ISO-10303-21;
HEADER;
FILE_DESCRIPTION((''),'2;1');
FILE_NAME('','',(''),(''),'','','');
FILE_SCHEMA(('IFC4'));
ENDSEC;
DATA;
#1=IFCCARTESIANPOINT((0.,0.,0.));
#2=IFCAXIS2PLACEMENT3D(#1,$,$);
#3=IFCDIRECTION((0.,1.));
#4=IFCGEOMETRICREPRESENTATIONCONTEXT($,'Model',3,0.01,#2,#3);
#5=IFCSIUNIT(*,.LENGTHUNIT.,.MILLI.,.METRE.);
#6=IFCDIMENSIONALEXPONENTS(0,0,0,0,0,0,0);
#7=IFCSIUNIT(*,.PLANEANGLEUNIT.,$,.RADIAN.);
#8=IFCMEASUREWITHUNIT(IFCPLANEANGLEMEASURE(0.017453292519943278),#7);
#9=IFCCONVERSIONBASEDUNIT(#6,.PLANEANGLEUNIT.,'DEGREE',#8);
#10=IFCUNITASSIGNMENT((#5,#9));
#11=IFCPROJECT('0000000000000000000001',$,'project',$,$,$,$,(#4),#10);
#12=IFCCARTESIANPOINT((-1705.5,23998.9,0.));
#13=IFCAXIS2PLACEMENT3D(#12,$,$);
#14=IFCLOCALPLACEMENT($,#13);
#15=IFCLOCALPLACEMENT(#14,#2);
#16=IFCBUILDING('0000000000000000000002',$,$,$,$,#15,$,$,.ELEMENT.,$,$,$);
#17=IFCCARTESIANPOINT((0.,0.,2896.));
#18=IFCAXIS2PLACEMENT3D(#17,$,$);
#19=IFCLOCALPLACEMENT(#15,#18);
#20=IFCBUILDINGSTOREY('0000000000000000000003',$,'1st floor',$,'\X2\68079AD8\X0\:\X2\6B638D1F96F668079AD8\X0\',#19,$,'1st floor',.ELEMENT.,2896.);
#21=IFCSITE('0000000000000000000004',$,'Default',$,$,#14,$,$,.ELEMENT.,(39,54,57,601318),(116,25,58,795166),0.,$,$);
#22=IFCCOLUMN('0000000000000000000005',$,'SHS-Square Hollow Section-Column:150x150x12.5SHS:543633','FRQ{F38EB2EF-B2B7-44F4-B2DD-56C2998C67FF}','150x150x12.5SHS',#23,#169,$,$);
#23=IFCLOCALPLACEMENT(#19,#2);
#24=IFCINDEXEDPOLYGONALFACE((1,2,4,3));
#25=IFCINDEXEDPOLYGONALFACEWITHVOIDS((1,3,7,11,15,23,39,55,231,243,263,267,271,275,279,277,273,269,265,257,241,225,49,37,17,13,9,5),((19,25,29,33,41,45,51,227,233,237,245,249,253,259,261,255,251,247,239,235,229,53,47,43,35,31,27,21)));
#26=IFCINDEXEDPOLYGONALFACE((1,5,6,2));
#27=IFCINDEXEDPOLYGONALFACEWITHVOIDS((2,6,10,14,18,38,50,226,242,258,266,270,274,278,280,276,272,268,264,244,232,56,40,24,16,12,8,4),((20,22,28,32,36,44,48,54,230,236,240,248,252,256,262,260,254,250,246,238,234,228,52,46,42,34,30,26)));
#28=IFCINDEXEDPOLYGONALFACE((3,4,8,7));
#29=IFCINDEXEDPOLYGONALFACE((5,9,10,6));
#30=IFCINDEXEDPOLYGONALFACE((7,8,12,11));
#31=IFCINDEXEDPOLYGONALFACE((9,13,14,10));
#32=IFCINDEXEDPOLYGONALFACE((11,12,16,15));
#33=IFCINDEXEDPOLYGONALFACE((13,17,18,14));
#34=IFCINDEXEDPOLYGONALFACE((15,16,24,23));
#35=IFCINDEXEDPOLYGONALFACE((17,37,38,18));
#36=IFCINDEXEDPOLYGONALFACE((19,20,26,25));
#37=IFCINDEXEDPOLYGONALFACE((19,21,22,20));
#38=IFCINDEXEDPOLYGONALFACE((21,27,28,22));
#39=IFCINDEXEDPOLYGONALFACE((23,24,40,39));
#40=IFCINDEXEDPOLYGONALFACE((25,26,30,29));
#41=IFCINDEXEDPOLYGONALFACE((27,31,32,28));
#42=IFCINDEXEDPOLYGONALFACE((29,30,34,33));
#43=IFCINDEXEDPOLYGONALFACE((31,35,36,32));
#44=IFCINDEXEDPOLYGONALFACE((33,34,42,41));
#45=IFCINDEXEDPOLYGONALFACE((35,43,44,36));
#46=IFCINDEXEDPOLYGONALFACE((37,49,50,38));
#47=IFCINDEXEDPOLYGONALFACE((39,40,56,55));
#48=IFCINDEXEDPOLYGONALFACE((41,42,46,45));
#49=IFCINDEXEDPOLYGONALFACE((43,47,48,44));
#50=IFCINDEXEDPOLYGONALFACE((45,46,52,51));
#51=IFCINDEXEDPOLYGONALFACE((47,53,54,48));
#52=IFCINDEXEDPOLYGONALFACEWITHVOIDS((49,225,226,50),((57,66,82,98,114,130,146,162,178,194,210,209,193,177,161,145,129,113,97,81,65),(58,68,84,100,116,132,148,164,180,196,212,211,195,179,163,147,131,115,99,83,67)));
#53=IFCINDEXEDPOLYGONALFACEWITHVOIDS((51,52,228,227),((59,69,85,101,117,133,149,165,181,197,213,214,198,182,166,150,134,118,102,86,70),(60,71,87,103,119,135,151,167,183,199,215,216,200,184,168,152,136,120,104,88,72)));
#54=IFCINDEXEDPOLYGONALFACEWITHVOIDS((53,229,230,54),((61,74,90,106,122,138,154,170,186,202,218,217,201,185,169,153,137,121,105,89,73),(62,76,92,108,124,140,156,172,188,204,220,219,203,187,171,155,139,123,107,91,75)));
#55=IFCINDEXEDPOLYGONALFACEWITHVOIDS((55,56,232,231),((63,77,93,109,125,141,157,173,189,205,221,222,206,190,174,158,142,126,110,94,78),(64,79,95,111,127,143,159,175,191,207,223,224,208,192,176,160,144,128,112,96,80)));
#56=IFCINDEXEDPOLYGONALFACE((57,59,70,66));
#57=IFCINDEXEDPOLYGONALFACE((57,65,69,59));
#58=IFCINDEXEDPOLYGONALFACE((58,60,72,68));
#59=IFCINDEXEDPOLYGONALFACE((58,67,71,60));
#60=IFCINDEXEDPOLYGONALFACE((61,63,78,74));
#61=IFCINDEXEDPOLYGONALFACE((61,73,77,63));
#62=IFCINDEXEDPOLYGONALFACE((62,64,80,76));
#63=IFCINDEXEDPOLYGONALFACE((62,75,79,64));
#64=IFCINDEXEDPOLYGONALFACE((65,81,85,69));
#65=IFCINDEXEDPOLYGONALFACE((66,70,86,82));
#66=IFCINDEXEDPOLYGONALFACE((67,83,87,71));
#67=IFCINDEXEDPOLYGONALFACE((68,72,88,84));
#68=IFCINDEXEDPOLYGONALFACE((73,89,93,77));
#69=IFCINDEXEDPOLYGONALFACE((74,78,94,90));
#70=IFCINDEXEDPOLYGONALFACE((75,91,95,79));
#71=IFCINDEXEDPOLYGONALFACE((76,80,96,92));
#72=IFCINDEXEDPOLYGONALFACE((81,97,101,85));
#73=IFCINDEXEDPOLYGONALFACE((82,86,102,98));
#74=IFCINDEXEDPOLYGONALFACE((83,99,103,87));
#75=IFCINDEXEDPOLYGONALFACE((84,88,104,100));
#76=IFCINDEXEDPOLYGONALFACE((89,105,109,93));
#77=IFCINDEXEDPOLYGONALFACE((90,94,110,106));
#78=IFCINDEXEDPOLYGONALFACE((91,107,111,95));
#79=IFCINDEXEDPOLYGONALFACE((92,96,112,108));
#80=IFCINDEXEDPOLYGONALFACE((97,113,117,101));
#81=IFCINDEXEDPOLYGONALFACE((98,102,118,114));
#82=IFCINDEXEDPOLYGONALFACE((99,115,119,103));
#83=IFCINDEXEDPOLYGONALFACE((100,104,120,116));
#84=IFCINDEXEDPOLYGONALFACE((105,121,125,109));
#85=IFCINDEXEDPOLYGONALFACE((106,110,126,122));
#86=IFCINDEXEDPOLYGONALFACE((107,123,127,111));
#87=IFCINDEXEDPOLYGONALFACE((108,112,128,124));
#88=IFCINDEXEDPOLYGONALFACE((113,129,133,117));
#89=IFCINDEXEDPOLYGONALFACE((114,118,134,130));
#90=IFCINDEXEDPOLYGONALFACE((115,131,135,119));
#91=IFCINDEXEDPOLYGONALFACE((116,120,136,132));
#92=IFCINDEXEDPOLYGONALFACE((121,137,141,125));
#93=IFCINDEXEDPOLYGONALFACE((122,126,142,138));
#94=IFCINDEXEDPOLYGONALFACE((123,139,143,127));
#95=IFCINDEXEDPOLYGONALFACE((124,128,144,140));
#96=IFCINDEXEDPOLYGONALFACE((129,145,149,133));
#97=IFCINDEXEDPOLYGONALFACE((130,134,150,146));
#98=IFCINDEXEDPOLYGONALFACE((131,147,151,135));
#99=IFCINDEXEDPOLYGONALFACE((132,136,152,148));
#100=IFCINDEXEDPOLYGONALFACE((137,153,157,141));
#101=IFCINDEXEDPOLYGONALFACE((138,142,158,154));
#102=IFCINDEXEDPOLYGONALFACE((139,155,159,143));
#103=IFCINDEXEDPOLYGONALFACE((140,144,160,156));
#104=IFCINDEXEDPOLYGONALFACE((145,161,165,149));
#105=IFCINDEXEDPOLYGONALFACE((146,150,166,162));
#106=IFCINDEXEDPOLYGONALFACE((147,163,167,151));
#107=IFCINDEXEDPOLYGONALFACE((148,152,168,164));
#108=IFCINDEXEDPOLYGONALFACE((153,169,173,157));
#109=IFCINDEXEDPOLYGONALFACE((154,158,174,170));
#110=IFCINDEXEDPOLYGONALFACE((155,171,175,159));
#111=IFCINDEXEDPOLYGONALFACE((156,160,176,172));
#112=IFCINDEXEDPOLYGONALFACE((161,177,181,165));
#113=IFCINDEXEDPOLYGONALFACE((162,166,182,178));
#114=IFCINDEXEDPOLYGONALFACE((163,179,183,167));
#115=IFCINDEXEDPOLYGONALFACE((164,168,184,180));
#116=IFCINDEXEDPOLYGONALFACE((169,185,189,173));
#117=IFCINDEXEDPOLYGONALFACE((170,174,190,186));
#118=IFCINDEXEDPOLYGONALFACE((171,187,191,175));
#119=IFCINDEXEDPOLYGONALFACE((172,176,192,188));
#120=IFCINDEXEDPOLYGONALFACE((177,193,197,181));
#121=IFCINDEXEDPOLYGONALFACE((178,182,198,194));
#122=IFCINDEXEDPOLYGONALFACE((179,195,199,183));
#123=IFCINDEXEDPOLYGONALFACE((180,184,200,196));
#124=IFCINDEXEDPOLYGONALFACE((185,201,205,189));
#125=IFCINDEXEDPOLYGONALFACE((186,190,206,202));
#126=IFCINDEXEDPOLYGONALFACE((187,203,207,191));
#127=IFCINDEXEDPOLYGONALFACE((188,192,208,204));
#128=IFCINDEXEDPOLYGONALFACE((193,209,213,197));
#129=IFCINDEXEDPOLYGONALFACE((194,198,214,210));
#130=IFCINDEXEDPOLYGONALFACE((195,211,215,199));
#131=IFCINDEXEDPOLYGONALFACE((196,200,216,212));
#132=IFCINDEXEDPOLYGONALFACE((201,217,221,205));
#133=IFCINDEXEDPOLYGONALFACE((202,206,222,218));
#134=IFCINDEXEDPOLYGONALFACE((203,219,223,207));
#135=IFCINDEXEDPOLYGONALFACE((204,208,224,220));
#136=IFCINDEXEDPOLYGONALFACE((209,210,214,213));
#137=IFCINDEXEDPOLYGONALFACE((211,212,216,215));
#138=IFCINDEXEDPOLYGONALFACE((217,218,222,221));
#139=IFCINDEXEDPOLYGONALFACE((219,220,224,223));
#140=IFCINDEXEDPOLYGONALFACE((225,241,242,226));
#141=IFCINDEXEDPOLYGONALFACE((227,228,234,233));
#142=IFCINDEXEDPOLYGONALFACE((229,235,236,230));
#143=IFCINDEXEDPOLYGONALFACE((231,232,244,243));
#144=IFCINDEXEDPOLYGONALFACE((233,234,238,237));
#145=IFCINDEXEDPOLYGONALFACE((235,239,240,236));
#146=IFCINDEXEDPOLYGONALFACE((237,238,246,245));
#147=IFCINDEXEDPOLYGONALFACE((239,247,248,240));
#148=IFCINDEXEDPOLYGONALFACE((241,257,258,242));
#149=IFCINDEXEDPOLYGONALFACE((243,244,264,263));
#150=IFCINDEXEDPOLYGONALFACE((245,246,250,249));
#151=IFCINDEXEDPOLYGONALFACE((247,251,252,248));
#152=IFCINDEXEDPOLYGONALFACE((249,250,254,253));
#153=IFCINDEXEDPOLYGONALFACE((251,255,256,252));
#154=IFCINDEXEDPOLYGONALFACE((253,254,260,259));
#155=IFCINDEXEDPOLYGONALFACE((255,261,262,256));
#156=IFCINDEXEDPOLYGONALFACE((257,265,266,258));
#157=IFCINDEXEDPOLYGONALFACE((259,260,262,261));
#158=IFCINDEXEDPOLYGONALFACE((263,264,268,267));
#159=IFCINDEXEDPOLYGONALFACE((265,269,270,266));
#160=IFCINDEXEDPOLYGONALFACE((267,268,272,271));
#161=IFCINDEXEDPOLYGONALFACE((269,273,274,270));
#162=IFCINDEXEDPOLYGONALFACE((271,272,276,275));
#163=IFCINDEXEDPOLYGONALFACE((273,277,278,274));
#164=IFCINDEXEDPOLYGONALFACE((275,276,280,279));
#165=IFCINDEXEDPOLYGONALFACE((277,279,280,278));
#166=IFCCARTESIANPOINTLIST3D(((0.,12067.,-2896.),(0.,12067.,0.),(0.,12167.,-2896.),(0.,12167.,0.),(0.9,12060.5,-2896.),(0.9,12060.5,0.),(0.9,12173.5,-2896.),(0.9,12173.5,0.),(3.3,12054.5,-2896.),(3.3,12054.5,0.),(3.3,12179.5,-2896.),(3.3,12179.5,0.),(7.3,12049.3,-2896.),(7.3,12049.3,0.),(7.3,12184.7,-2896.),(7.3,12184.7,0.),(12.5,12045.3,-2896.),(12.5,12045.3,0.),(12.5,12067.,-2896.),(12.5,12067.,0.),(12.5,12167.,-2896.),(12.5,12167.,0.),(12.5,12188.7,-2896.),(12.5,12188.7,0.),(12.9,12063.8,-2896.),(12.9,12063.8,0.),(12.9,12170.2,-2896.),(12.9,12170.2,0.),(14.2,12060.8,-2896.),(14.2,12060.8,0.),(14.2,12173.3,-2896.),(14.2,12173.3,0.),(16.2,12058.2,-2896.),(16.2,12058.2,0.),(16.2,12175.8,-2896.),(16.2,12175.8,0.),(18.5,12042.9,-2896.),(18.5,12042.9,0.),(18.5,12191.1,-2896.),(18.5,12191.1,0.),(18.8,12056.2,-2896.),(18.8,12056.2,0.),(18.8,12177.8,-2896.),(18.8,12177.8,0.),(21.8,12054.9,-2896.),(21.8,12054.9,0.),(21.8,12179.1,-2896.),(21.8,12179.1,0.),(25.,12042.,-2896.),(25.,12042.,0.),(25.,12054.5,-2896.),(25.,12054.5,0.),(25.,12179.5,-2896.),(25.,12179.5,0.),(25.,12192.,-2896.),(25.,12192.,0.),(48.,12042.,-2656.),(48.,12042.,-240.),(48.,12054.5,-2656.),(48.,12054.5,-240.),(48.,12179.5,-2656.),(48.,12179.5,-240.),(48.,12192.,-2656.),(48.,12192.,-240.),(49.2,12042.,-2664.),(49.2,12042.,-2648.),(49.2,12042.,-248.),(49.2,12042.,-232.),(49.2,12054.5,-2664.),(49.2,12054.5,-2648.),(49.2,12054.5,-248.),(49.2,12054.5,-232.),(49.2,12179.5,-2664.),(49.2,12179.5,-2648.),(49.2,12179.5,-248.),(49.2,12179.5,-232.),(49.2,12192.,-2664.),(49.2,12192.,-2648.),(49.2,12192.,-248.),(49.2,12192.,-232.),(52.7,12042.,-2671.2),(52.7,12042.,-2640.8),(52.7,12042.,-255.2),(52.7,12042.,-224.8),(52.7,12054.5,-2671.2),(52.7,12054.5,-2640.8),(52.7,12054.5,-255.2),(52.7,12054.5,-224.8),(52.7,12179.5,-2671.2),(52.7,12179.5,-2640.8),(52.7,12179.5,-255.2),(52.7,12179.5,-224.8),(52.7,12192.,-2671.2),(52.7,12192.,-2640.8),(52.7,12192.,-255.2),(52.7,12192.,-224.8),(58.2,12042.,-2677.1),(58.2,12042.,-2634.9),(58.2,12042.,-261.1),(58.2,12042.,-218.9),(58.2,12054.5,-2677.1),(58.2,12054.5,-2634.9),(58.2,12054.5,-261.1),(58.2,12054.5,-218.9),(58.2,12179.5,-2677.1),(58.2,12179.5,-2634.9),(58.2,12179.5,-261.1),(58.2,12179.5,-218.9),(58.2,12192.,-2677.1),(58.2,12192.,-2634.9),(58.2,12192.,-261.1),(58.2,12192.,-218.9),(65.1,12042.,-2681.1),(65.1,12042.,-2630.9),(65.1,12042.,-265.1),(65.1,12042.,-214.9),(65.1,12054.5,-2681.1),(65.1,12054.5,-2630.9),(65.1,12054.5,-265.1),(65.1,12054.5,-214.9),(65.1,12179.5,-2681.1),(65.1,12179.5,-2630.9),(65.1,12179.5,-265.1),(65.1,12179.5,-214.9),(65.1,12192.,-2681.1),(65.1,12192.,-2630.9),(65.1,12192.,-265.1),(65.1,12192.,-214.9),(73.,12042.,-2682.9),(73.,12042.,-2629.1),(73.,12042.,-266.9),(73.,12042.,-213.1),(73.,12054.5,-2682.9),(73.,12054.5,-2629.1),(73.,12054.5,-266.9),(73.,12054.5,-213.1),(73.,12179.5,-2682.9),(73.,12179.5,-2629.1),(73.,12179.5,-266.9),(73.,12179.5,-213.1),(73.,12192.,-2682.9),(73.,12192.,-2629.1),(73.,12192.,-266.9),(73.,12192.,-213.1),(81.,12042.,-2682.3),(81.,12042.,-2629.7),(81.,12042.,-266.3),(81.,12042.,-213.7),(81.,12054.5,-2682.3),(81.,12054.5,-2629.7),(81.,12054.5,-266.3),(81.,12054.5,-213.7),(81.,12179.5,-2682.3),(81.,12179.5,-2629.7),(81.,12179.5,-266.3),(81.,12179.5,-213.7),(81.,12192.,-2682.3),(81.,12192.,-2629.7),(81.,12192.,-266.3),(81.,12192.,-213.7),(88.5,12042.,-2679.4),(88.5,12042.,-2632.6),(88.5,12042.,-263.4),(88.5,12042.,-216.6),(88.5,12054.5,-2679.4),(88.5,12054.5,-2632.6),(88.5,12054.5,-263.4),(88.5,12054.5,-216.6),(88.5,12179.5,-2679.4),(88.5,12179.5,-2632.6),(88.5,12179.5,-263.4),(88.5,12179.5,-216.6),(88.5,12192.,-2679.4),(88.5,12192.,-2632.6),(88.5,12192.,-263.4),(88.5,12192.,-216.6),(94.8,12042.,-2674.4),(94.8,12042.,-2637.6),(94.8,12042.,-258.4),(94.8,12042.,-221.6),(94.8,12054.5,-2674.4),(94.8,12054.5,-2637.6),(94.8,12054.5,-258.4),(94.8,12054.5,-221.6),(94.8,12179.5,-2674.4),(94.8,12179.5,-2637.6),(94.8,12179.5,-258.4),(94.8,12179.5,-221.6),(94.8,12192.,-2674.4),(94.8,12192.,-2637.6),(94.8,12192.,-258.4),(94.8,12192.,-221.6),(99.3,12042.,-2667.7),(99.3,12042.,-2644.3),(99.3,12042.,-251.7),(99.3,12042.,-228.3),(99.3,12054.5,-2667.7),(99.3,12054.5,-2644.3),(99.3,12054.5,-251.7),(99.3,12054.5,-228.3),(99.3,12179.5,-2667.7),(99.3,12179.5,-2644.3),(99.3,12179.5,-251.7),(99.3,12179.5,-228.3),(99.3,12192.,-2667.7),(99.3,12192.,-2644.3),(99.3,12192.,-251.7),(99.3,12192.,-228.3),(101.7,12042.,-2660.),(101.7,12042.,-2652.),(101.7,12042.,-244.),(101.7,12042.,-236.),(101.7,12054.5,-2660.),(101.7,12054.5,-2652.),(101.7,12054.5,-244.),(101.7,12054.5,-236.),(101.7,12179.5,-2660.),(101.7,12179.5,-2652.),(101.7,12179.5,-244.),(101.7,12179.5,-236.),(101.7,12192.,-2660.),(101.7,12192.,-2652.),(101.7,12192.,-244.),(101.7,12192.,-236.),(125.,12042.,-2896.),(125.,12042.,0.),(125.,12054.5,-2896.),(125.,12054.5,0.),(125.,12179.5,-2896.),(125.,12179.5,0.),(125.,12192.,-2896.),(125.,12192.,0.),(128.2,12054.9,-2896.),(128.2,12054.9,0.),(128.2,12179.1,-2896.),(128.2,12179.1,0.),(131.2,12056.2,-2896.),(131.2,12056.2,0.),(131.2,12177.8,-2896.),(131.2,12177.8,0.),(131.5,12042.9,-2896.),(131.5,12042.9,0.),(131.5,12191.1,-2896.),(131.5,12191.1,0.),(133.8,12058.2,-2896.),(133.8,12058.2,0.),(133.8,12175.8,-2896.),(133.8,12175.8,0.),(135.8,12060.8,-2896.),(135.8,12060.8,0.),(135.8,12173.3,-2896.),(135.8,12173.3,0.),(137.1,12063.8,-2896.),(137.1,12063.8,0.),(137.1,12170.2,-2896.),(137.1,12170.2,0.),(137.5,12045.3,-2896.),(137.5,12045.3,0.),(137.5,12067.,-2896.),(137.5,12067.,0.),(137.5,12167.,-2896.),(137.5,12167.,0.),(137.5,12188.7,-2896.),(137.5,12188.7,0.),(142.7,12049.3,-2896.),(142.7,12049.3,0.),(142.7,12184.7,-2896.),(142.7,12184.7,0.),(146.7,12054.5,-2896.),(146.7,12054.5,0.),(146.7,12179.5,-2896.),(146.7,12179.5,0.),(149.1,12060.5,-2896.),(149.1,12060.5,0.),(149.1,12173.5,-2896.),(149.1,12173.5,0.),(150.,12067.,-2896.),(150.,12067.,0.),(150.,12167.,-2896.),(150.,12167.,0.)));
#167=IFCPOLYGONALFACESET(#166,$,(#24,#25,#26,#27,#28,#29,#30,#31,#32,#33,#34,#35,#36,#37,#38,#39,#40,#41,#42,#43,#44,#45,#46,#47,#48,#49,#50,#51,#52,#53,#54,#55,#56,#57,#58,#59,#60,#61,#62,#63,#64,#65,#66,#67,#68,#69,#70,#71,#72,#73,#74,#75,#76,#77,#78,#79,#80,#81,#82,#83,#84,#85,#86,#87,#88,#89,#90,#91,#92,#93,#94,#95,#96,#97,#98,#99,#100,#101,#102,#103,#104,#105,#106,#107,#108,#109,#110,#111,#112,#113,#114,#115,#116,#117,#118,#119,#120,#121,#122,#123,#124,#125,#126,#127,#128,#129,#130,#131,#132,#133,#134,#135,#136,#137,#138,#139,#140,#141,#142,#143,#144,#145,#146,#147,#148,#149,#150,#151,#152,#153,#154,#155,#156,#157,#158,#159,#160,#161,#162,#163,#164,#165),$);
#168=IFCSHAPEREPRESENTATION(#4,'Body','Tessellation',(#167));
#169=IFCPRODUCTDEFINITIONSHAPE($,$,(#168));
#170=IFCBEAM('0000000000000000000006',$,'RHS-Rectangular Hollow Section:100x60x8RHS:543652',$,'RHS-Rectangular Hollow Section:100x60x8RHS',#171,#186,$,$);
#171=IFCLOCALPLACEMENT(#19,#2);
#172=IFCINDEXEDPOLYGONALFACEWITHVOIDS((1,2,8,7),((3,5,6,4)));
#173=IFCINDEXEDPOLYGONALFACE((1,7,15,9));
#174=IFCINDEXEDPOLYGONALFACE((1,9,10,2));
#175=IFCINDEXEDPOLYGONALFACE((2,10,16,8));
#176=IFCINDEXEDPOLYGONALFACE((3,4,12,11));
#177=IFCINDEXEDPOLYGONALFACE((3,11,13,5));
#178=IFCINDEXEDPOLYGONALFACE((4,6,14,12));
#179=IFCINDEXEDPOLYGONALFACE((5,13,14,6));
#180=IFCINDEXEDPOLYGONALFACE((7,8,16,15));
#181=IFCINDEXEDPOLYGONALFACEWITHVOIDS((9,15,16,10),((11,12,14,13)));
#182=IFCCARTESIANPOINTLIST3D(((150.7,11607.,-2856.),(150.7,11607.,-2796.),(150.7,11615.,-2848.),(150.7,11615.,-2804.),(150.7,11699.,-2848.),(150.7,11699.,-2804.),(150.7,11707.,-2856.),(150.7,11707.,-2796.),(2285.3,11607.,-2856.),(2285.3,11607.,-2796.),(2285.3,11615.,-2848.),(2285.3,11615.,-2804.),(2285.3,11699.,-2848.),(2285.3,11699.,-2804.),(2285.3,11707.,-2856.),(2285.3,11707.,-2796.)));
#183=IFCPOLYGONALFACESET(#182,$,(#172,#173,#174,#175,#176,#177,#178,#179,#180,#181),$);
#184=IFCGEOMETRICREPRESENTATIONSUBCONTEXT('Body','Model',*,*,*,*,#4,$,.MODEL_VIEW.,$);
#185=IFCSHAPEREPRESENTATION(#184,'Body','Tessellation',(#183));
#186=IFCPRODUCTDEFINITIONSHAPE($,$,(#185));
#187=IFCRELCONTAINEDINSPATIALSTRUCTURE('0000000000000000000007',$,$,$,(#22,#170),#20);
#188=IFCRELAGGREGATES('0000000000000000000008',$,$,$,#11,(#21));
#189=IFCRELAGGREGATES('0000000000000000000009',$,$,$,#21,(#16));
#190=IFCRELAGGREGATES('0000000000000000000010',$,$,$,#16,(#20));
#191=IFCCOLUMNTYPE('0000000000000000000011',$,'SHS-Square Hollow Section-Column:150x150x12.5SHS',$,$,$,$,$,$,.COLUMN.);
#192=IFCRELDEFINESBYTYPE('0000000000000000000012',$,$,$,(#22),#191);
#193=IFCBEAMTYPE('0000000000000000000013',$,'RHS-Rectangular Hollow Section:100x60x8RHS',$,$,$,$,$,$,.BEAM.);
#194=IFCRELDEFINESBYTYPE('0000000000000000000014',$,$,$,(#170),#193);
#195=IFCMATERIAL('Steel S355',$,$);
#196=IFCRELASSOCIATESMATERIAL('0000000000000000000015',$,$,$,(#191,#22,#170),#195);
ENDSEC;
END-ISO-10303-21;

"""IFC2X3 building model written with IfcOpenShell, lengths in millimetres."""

from ifc_helpers import new_model, entity, si_unit, converted_unit, direction, frame, frame_2d, origin, origin_2d, place, context, subcontext, project, spatial, circle_curve, rectangle, hollow_rectangle, outline, extrude, boolean, material, type_object, element, save


model = new_model("IFC2X3")

# Units and contexts
model_context = context("Model", 3, precision=0.01, world=origin(), true_north=direction((0.0, 1.0)))
body_context = subcontext(model_context, "Body", "Model", "MODEL_VIEW")
ifc_project = project(units=[si_unit("LENGTHUNIT", "METRE", prefix="MILLI"), converted_unit("PLANEANGLEUNIT", "DEGREE", entity("IfcPlaneAngleMeasure", 0.017453292519943278), si_unit("PLANEANGLEUNIT", "RADIAN"), dimensions=[0, 0, 0, 0, 0, 0, 0])], contexts=[model_context])

# Site, building, storey
site_placement = place(None, frame((-1705.5, 23998.9, 0.0)))
site = spatial("IfcSite", under=ifc_project, at=site_placement, Name="Default", CompositionType="ELEMENT", RefLatitude=(39, 54, 57, 601318), RefLongitude=(116, 25, 58, 795166), RefElevation=0.0)
building_placement = place(site_placement, origin())
building = spatial("IfcBuilding", under=site, at=building_placement, CompositionType="ELEMENT")
storey_placement = place(building_placement, frame((0.0, 0.0, 2896.0)))
storey = spatial("IfcBuildingStorey", under=building, at=storey_placement, Name="1st floor", ObjectType="标高:正负零标高", LongName="1st floor", CompositionType="ELEMENT", Elevation=2896.0)

# Shared definitions
ifc_material_1 = material(Name="Steel S355")

# Column, openings
column_type_1 = type_object("IfcColumnType", Name="SHS-Square Hollow Section-Column:150x150x12.5SHS", PredefinedType="COLUMN", material=ifc_material_1)
column_1_placement = place(storey_placement, frame((75.0, 12117.0, 0.0), z_axis=(0.0, 0.0, 1.0), x_axis=(0.0, -1.0, 0.0)))
column_1 = element("IfcColumn", 1, at=column_1_placement, inside=storey, type_object=column_type_1, material=ifc_material_1, Name="SHS-Square Hollow Section-Column:150x150x12.5SHS:543633", Description="FRQ{F38EB2EF-B2B7-44F4-B2DD-56C2998C67FF}", ObjectType="150x150x12.5SHS", context=model_context, shape_type="SweptSolid", body=[
    extrude(hollow_rectangle(XDim=150.0, YDim=150.0, WallThickness=12.5, InnerFilletRadius=12.5, OuterFilletRadius=25.0, at=origin_2d()), origin(), (0.0, 0.0, -1.0), 2896.0),
])
opening_1_placement = place(column_1_placement, frame((175.1, 0.0, -2896.0), z_axis=(-1.0, 0.0, 0.0), x_axis=(0.0, -1.0, 0.0)))
element("IfcOpeningElement", 2, at=opening_1_placement, cuts=column_1, ObjectType="Opening", context=model_context, shape_type="SweptSolid", body=[
    extrude(outline(circle_curve(frame_2d((0.0, 240.0), x_axis=(1.0, 0.0)), 27.0)), origin(), (0.0, 0.0, 1.0), 350.2),
])
opening_2_placement = place(column_1_placement, frame((175.1, 0.0, 0.0), z_axis=(-1.0, 0.0, 0.0), x_axis=(0.0, -1.0, 0.0)))
element("IfcOpeningElement", 3, at=opening_2_placement, cuts=column_1, ObjectType="Opening", context=model_context, shape_type="SweptSolid", body=[
    extrude(outline(circle_curve(frame_2d((0.0, -240.0), x_axis=(1.0, 0.0)), 27.0)), origin(), (0.0, 0.0, 1.0), 350.2),
])

# Beam
beam_type_1 = type_object("IfcBeamType", Name="RHS-Rectangular Hollow Section:100x60x8RHS", PredefinedType="BEAM")
beam_1_placement = place(storey_placement, frame((150.7, 11707.0, -2826.0)))
element("IfcBeam", 4, at=beam_1_placement, inside=storey, type_object=beam_type_1, material=ifc_material_1, Name="RHS-Rectangular Hollow Section:100x60x8RHS:543652", ObjectType="RHS-Rectangular Hollow Section:100x60x8RHS", context=body_context, shape_type="SweptSolid", body=[
    boolean("DIFFERENCE", extrude(rectangle(XDim=60.0, YDim=100.0, at=frame_2d((0.0, 0.0), x_axis=(1.0, 0.0))), frame((0.0, -50.0, 0.0), z_axis=(1.0, 0.0, 0.0), x_axis=(0.0, 0.0, -1.0)), (0.0, 0.0, 1.0), 2134.6), extrude(rectangle(XDim=44.0, YDim=84.0, at=frame_2d((0.0, 0.0), x_axis=(0.0, 1.0))), frame((2134.6, -50.0, 0.0), z_axis=(-1.0, 0.0, 0.0), x_axis=(0.0, 1.0, 0.0)), (0.0, 0.0, 1.0), 2134.6)),
])

save(model, "model.ifc")
